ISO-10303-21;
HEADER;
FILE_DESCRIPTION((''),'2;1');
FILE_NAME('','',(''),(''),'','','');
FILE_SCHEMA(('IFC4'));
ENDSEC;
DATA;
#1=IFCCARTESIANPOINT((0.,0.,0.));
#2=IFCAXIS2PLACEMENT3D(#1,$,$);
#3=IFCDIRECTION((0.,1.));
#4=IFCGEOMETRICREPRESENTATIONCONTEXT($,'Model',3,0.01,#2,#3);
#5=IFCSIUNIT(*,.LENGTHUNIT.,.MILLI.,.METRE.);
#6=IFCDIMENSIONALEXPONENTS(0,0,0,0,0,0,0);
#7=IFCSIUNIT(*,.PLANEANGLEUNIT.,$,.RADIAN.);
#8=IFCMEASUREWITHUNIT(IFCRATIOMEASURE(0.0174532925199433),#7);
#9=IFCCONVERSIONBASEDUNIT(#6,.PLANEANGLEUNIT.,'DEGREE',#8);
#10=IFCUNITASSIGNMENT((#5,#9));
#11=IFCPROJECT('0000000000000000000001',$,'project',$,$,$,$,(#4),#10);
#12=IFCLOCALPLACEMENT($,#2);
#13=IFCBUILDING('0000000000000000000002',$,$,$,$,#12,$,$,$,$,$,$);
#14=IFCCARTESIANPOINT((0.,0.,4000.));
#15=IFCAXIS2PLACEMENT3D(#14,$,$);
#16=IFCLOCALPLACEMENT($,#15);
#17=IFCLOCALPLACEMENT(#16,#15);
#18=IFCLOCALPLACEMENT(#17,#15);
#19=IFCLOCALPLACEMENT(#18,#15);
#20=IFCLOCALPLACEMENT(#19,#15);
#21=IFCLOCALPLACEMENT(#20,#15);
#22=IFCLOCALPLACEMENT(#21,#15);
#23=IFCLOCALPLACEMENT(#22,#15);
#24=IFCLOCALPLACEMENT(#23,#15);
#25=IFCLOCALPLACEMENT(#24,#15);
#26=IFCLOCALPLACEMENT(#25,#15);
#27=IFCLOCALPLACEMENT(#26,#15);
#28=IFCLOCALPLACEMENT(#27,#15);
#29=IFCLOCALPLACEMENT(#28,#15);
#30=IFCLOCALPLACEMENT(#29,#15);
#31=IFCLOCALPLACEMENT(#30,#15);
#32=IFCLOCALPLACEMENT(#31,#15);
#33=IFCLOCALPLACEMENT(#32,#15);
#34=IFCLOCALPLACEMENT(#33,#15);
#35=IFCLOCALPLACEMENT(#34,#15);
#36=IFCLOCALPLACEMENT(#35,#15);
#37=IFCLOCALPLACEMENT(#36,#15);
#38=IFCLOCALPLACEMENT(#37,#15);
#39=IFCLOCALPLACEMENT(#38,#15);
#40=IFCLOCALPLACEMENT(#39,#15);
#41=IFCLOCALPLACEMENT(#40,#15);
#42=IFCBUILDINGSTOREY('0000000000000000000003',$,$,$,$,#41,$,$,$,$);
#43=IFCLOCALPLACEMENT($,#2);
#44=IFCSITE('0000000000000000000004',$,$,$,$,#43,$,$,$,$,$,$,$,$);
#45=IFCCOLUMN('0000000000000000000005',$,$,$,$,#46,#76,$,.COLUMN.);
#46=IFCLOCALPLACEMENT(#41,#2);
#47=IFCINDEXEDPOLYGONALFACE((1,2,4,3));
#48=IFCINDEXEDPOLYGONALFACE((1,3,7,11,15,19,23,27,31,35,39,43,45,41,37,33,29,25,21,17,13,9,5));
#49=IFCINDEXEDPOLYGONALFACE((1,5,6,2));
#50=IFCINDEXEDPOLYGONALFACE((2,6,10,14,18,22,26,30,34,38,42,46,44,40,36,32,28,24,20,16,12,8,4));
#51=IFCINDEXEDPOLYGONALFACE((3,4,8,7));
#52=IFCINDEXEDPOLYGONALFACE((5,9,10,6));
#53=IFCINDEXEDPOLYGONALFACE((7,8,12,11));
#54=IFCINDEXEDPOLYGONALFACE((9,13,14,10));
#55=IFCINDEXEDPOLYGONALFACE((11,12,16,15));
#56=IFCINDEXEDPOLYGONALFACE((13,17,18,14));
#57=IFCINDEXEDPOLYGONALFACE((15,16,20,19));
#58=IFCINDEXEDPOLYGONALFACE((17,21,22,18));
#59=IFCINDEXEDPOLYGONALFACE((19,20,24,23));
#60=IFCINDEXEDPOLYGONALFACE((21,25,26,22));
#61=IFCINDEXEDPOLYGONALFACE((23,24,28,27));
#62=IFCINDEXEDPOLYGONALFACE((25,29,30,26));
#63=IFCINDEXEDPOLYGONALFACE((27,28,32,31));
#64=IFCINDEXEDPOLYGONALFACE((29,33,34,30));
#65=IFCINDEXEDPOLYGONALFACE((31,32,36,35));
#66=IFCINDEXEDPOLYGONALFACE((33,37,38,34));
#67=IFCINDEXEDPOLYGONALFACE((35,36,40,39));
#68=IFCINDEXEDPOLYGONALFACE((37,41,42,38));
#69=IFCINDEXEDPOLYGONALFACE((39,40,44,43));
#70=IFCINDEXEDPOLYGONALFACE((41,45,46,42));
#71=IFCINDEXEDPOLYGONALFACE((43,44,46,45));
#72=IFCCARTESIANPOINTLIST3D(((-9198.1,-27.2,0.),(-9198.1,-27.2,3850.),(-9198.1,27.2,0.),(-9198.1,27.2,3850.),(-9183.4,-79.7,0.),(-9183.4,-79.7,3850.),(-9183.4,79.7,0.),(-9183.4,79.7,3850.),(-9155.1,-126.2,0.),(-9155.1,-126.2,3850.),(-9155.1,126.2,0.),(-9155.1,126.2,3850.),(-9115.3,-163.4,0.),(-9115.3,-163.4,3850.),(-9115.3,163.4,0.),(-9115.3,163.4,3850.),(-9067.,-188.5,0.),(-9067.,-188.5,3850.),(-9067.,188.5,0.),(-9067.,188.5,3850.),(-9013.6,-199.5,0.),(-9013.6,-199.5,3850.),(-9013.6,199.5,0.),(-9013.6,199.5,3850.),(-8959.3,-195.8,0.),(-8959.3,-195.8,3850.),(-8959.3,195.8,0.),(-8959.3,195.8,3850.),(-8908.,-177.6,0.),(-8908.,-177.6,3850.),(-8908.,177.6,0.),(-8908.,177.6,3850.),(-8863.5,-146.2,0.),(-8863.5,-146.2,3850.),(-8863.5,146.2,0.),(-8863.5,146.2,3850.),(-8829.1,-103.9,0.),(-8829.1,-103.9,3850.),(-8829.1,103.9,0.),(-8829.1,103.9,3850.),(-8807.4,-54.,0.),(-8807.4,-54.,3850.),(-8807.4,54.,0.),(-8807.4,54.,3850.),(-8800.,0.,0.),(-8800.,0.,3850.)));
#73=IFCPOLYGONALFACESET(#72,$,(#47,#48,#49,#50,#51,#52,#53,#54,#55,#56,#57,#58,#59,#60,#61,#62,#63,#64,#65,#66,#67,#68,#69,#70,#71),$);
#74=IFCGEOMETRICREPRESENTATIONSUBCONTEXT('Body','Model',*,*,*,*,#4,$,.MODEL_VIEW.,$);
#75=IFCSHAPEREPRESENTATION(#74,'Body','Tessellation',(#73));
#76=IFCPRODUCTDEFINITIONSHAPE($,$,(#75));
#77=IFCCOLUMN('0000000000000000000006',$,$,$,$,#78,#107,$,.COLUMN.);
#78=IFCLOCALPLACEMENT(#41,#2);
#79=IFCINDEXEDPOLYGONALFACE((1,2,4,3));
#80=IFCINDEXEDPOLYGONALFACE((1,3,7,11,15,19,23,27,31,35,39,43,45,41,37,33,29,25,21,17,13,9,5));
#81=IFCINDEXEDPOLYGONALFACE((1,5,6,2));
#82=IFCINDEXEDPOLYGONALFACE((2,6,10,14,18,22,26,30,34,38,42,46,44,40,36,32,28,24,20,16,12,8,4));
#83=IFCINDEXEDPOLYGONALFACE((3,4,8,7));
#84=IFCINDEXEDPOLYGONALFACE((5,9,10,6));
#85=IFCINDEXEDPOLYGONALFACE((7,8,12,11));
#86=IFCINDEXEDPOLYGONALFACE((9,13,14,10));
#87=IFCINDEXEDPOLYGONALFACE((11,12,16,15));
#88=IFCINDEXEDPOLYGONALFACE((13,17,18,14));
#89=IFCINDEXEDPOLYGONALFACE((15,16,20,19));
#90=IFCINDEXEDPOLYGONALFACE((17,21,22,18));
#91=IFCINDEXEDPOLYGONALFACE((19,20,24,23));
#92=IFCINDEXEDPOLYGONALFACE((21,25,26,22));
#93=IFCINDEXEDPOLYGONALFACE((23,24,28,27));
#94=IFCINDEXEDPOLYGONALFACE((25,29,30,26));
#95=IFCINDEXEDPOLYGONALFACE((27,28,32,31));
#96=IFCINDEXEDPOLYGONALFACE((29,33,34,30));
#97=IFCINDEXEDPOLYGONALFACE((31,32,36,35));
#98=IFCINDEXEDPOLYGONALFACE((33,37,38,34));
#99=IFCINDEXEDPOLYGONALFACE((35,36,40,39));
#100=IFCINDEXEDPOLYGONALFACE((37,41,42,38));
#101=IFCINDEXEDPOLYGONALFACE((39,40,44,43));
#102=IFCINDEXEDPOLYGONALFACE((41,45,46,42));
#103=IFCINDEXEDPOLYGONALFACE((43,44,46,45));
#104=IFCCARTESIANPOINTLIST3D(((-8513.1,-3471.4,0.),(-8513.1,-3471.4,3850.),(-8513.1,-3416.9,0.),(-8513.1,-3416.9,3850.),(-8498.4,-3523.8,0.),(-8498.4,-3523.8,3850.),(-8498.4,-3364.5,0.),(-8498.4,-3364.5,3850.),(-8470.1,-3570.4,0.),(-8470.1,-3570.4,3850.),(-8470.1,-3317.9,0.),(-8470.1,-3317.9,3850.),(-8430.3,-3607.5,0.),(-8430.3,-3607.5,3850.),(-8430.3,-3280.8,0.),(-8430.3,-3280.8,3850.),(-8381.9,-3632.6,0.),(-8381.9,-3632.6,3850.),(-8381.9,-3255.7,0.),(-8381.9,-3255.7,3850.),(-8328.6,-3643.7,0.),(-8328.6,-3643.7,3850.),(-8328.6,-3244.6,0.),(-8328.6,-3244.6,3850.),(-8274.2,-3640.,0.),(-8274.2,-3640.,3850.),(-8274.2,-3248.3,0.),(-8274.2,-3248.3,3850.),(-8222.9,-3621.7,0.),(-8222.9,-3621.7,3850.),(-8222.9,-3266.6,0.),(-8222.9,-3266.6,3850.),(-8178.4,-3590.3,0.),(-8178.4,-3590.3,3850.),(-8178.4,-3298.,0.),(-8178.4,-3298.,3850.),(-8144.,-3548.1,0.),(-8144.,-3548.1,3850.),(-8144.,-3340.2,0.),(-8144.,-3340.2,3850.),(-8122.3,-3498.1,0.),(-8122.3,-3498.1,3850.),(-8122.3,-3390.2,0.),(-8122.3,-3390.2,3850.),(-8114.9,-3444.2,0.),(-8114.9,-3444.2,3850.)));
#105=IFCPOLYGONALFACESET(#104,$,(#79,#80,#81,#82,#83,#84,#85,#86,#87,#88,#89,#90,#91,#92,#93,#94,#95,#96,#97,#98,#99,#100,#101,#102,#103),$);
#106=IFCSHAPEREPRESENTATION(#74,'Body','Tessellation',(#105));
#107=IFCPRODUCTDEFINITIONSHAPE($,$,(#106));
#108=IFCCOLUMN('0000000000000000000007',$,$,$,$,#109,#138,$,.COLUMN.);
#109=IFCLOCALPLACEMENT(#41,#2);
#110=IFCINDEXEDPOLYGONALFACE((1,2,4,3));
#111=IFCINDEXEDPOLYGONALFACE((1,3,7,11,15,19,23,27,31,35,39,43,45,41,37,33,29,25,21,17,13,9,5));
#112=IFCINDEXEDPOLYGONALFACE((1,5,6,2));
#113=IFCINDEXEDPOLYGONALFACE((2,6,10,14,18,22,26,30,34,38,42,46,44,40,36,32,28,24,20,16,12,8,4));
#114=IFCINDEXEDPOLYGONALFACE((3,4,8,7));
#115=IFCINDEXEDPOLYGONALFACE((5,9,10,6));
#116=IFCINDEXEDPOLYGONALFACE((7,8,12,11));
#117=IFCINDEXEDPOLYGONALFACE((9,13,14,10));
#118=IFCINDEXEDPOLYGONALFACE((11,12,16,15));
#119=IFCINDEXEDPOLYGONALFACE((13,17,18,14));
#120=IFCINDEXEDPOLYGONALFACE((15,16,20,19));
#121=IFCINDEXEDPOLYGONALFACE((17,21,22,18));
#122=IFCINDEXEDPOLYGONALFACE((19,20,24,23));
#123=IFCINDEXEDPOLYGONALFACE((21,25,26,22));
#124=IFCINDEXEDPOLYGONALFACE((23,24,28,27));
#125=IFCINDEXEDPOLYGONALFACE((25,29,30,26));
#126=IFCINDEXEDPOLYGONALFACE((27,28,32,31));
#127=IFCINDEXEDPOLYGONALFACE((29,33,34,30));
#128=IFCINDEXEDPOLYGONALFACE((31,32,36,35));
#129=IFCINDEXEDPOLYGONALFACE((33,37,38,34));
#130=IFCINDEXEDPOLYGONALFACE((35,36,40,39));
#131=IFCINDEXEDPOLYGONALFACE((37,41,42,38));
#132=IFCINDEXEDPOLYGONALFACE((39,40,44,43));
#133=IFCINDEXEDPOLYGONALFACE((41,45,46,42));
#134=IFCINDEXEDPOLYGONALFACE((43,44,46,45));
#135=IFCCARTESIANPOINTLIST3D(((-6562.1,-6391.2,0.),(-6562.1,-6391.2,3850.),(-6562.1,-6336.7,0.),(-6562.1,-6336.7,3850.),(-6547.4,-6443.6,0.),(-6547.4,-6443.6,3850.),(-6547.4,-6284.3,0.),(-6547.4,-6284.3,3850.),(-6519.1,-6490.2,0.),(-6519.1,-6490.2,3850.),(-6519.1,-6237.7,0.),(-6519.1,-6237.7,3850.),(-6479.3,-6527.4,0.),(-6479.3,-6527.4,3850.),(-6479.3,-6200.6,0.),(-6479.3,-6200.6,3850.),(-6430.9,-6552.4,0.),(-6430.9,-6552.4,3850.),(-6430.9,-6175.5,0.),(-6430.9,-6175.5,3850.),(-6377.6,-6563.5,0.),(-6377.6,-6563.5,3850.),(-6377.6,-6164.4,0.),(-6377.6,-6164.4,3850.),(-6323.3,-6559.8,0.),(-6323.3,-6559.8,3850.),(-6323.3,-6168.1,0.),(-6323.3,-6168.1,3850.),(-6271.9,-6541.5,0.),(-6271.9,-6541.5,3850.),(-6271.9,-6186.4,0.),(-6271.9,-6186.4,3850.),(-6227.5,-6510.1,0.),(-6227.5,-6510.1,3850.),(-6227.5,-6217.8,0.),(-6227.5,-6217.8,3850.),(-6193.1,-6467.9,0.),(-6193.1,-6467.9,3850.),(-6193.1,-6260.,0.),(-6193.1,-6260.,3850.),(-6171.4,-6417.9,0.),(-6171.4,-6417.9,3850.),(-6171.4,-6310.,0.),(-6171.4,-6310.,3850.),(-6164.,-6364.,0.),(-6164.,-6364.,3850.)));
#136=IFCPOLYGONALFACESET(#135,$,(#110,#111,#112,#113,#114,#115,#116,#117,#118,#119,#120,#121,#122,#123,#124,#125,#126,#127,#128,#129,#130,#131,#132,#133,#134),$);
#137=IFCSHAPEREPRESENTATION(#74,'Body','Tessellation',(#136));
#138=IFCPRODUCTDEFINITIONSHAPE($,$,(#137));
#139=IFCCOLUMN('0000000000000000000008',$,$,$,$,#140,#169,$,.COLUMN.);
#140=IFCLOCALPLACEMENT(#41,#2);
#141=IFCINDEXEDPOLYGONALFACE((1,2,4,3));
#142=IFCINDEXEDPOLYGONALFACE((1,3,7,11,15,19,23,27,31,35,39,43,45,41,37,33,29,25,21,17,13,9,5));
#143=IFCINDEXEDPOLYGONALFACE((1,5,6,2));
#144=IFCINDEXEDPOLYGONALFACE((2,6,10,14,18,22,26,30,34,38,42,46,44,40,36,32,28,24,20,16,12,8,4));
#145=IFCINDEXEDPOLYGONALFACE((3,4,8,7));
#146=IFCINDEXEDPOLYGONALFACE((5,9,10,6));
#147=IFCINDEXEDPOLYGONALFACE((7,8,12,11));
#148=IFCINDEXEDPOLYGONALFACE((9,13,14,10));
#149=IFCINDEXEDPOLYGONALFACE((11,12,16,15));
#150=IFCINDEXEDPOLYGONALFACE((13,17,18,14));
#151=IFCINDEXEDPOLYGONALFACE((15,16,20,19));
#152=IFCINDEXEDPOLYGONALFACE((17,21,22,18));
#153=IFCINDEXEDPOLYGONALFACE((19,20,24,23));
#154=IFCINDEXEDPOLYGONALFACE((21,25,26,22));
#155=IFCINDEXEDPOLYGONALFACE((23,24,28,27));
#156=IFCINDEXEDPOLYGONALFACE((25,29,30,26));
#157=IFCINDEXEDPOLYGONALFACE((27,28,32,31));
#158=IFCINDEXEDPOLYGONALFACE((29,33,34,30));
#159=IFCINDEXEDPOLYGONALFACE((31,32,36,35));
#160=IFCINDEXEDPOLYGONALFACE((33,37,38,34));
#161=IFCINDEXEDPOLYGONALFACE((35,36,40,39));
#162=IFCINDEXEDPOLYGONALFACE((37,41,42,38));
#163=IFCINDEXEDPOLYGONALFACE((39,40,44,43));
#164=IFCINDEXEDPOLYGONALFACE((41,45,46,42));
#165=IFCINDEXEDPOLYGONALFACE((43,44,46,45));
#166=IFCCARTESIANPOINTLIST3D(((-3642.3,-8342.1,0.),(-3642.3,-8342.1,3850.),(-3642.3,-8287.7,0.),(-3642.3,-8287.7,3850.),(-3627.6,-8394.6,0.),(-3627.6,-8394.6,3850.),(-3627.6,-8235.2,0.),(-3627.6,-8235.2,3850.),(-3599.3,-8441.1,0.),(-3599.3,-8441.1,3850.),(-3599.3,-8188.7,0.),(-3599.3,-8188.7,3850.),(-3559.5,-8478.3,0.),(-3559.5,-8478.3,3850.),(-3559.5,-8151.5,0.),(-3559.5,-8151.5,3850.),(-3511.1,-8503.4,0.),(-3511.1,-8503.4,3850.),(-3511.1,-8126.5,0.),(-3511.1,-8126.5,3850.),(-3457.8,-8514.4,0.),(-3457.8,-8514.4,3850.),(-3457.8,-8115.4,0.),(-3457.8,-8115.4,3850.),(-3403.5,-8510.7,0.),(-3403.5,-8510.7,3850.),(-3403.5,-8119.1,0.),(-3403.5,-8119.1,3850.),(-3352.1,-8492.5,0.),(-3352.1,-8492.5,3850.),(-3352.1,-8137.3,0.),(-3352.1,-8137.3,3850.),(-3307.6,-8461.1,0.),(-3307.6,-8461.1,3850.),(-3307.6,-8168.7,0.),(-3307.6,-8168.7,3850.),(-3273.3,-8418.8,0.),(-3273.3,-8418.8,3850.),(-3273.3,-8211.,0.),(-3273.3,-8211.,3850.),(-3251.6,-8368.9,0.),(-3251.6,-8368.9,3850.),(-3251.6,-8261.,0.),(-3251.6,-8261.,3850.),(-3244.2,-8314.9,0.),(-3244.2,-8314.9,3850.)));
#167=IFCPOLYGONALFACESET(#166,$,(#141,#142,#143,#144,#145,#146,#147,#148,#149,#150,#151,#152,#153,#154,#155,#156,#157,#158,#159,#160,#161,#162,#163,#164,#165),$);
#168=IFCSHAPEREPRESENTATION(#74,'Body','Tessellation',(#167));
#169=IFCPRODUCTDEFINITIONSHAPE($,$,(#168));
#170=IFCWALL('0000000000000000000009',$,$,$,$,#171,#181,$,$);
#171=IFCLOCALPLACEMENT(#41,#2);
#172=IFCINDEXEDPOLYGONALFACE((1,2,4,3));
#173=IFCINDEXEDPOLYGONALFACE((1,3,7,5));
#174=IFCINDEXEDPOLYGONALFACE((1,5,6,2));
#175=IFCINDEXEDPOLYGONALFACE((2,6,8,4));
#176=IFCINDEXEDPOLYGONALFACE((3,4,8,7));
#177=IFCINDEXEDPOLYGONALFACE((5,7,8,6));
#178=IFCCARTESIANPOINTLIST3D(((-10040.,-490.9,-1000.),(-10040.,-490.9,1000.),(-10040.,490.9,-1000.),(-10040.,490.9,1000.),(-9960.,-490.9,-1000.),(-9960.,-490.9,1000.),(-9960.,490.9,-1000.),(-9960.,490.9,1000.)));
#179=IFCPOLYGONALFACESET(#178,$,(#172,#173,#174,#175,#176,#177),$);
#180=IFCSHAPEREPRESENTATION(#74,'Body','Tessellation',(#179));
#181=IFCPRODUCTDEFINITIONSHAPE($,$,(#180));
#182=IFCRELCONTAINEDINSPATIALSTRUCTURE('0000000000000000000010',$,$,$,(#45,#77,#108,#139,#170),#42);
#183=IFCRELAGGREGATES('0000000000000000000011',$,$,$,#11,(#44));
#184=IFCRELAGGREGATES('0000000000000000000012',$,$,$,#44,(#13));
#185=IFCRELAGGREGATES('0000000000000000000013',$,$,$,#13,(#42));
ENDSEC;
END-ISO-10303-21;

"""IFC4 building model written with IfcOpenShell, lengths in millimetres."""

from ifc_helpers import new_model, entity, si_unit, converted_unit, direction, frame, origin, origin_2d, place, context, subcontext, project, spatial, rectangle, circle, extrude, element, save


model = new_model("IFC4")

# Units and contexts
model_context = context("Model", 3, precision=0.01, world=origin(), true_north=direction((0.0, 1.0)))
body_context = subcontext(model_context, "Body", "Model", "MODEL_VIEW")
ifc_project = project(units=[si_unit("LENGTHUNIT", "METRE", prefix="MILLI"), converted_unit("PLANEANGLEUNIT", "DEGREE", entity("IfcRatioMeasure", 0.0174532925199433), si_unit("PLANEANGLEUNIT", "RADIAN"), dimensions=[0, 0, 0, 0, 0, 0, 0])], contexts=[model_context])

# Site, building, storey
site_placement = place(None, origin())
site = spatial("IfcSite", under=ifc_project, at=site_placement)
building_placement = place(None, origin())
building = spatial("IfcBuilding", under=site, at=building_placement)
placement_1 = place(None, frame((0.0, 0.0, 4000.0)))
placement_2 = place(placement_1, frame((0.0, 0.0, 4000.0)))
placement_3 = place(placement_2, frame((0.0, 0.0, 4000.0)))
placement_4 = place(placement_3, frame((0.0, 0.0, 4000.0)))
placement_5 = place(placement_4, frame((0.0, 0.0, 4000.0)))
placement_6 = place(placement_5, frame((0.0, 0.0, 4000.0)))
placement_7 = place(placement_6, frame((0.0, 0.0, 4000.0)))
placement_8 = place(placement_7, frame((0.0, 0.0, 4000.0)))
placement_9 = place(placement_8, frame((0.0, 0.0, 4000.0)))
placement_10 = place(placement_9, frame((0.0, 0.0, 4000.0)))
placement_11 = place(placement_10, frame((0.0, 0.0, 4000.0)))
placement_12 = place(placement_11, frame((0.0, 0.0, 4000.0)))
placement_13 = place(placement_12, frame((0.0, 0.0, 4000.0)))
placement_14 = place(placement_13, frame((0.0, 0.0, 4000.0)))
placement_15 = place(placement_14, frame((0.0, 0.0, 4000.0)))
placement_16 = place(placement_15, frame((0.0, 0.0, 4000.0)))
placement_17 = place(placement_16, frame((0.0, 0.0, 4000.0)))
placement_18 = place(placement_17, frame((0.0, 0.0, 4000.0)))
placement_19 = place(placement_18, frame((0.0, 0.0, 4000.0)))
placement_20 = place(placement_19, frame((0.0, 0.0, 4000.0)))
placement_21 = place(placement_20, frame((0.0, 0.0, 4000.0)))
placement_22 = place(placement_21, frame((0.0, 0.0, 4000.0)))
placement_23 = place(placement_22, frame((0.0, 0.0, 4000.0)))
placement_24 = place(placement_23, frame((0.0, 0.0, 4000.0)))
placement_25 = place(placement_24, frame((0.0, 0.0, 4000.0)))
storey_placement = place(placement_25, frame((0.0, 0.0, 4000.0)))
storey = spatial("IfcBuildingStorey", under=building, at=storey_placement)

# Columns
for number, where in (
    (1, (-9000.0, 0.0, 0.0)),
    (2, (-8314.9, -3444.2, 0.0)),
    (3, (-6364.0, -6364.0, 0.0)),
    (4, (-3444.2, -8314.9, 0.0)),
):
    element("IfcColumn", number, at=place(storey_placement, frame(where)), inside=storey, PredefinedType="COLUMN", context=body_context, shape_type="SweptSolid", body=[
        extrude(circle(Radius=200.0, at=origin_2d()), origin(), (0.0, 0.0, 1.0), 3850.0),
    ])

# Wall
wall_1_placement = place(storey_placement, frame((-10000.0, 0.0, -1000.0), z_axis=(0.0, 0.0, 1.0), x_axis=(0.000874, -10000.0, 0.0)))
element("IfcWall", 5, at=wall_1_placement, inside=storey, context=body_context, shape_type="SweptSolid", body=[
    extrude(rectangle(XDim=981.7, YDim=80.0, at=origin_2d()), origin(), (0.0, 0.0, 1.0), 2000.0),
])

save(model, "model.ifc")
